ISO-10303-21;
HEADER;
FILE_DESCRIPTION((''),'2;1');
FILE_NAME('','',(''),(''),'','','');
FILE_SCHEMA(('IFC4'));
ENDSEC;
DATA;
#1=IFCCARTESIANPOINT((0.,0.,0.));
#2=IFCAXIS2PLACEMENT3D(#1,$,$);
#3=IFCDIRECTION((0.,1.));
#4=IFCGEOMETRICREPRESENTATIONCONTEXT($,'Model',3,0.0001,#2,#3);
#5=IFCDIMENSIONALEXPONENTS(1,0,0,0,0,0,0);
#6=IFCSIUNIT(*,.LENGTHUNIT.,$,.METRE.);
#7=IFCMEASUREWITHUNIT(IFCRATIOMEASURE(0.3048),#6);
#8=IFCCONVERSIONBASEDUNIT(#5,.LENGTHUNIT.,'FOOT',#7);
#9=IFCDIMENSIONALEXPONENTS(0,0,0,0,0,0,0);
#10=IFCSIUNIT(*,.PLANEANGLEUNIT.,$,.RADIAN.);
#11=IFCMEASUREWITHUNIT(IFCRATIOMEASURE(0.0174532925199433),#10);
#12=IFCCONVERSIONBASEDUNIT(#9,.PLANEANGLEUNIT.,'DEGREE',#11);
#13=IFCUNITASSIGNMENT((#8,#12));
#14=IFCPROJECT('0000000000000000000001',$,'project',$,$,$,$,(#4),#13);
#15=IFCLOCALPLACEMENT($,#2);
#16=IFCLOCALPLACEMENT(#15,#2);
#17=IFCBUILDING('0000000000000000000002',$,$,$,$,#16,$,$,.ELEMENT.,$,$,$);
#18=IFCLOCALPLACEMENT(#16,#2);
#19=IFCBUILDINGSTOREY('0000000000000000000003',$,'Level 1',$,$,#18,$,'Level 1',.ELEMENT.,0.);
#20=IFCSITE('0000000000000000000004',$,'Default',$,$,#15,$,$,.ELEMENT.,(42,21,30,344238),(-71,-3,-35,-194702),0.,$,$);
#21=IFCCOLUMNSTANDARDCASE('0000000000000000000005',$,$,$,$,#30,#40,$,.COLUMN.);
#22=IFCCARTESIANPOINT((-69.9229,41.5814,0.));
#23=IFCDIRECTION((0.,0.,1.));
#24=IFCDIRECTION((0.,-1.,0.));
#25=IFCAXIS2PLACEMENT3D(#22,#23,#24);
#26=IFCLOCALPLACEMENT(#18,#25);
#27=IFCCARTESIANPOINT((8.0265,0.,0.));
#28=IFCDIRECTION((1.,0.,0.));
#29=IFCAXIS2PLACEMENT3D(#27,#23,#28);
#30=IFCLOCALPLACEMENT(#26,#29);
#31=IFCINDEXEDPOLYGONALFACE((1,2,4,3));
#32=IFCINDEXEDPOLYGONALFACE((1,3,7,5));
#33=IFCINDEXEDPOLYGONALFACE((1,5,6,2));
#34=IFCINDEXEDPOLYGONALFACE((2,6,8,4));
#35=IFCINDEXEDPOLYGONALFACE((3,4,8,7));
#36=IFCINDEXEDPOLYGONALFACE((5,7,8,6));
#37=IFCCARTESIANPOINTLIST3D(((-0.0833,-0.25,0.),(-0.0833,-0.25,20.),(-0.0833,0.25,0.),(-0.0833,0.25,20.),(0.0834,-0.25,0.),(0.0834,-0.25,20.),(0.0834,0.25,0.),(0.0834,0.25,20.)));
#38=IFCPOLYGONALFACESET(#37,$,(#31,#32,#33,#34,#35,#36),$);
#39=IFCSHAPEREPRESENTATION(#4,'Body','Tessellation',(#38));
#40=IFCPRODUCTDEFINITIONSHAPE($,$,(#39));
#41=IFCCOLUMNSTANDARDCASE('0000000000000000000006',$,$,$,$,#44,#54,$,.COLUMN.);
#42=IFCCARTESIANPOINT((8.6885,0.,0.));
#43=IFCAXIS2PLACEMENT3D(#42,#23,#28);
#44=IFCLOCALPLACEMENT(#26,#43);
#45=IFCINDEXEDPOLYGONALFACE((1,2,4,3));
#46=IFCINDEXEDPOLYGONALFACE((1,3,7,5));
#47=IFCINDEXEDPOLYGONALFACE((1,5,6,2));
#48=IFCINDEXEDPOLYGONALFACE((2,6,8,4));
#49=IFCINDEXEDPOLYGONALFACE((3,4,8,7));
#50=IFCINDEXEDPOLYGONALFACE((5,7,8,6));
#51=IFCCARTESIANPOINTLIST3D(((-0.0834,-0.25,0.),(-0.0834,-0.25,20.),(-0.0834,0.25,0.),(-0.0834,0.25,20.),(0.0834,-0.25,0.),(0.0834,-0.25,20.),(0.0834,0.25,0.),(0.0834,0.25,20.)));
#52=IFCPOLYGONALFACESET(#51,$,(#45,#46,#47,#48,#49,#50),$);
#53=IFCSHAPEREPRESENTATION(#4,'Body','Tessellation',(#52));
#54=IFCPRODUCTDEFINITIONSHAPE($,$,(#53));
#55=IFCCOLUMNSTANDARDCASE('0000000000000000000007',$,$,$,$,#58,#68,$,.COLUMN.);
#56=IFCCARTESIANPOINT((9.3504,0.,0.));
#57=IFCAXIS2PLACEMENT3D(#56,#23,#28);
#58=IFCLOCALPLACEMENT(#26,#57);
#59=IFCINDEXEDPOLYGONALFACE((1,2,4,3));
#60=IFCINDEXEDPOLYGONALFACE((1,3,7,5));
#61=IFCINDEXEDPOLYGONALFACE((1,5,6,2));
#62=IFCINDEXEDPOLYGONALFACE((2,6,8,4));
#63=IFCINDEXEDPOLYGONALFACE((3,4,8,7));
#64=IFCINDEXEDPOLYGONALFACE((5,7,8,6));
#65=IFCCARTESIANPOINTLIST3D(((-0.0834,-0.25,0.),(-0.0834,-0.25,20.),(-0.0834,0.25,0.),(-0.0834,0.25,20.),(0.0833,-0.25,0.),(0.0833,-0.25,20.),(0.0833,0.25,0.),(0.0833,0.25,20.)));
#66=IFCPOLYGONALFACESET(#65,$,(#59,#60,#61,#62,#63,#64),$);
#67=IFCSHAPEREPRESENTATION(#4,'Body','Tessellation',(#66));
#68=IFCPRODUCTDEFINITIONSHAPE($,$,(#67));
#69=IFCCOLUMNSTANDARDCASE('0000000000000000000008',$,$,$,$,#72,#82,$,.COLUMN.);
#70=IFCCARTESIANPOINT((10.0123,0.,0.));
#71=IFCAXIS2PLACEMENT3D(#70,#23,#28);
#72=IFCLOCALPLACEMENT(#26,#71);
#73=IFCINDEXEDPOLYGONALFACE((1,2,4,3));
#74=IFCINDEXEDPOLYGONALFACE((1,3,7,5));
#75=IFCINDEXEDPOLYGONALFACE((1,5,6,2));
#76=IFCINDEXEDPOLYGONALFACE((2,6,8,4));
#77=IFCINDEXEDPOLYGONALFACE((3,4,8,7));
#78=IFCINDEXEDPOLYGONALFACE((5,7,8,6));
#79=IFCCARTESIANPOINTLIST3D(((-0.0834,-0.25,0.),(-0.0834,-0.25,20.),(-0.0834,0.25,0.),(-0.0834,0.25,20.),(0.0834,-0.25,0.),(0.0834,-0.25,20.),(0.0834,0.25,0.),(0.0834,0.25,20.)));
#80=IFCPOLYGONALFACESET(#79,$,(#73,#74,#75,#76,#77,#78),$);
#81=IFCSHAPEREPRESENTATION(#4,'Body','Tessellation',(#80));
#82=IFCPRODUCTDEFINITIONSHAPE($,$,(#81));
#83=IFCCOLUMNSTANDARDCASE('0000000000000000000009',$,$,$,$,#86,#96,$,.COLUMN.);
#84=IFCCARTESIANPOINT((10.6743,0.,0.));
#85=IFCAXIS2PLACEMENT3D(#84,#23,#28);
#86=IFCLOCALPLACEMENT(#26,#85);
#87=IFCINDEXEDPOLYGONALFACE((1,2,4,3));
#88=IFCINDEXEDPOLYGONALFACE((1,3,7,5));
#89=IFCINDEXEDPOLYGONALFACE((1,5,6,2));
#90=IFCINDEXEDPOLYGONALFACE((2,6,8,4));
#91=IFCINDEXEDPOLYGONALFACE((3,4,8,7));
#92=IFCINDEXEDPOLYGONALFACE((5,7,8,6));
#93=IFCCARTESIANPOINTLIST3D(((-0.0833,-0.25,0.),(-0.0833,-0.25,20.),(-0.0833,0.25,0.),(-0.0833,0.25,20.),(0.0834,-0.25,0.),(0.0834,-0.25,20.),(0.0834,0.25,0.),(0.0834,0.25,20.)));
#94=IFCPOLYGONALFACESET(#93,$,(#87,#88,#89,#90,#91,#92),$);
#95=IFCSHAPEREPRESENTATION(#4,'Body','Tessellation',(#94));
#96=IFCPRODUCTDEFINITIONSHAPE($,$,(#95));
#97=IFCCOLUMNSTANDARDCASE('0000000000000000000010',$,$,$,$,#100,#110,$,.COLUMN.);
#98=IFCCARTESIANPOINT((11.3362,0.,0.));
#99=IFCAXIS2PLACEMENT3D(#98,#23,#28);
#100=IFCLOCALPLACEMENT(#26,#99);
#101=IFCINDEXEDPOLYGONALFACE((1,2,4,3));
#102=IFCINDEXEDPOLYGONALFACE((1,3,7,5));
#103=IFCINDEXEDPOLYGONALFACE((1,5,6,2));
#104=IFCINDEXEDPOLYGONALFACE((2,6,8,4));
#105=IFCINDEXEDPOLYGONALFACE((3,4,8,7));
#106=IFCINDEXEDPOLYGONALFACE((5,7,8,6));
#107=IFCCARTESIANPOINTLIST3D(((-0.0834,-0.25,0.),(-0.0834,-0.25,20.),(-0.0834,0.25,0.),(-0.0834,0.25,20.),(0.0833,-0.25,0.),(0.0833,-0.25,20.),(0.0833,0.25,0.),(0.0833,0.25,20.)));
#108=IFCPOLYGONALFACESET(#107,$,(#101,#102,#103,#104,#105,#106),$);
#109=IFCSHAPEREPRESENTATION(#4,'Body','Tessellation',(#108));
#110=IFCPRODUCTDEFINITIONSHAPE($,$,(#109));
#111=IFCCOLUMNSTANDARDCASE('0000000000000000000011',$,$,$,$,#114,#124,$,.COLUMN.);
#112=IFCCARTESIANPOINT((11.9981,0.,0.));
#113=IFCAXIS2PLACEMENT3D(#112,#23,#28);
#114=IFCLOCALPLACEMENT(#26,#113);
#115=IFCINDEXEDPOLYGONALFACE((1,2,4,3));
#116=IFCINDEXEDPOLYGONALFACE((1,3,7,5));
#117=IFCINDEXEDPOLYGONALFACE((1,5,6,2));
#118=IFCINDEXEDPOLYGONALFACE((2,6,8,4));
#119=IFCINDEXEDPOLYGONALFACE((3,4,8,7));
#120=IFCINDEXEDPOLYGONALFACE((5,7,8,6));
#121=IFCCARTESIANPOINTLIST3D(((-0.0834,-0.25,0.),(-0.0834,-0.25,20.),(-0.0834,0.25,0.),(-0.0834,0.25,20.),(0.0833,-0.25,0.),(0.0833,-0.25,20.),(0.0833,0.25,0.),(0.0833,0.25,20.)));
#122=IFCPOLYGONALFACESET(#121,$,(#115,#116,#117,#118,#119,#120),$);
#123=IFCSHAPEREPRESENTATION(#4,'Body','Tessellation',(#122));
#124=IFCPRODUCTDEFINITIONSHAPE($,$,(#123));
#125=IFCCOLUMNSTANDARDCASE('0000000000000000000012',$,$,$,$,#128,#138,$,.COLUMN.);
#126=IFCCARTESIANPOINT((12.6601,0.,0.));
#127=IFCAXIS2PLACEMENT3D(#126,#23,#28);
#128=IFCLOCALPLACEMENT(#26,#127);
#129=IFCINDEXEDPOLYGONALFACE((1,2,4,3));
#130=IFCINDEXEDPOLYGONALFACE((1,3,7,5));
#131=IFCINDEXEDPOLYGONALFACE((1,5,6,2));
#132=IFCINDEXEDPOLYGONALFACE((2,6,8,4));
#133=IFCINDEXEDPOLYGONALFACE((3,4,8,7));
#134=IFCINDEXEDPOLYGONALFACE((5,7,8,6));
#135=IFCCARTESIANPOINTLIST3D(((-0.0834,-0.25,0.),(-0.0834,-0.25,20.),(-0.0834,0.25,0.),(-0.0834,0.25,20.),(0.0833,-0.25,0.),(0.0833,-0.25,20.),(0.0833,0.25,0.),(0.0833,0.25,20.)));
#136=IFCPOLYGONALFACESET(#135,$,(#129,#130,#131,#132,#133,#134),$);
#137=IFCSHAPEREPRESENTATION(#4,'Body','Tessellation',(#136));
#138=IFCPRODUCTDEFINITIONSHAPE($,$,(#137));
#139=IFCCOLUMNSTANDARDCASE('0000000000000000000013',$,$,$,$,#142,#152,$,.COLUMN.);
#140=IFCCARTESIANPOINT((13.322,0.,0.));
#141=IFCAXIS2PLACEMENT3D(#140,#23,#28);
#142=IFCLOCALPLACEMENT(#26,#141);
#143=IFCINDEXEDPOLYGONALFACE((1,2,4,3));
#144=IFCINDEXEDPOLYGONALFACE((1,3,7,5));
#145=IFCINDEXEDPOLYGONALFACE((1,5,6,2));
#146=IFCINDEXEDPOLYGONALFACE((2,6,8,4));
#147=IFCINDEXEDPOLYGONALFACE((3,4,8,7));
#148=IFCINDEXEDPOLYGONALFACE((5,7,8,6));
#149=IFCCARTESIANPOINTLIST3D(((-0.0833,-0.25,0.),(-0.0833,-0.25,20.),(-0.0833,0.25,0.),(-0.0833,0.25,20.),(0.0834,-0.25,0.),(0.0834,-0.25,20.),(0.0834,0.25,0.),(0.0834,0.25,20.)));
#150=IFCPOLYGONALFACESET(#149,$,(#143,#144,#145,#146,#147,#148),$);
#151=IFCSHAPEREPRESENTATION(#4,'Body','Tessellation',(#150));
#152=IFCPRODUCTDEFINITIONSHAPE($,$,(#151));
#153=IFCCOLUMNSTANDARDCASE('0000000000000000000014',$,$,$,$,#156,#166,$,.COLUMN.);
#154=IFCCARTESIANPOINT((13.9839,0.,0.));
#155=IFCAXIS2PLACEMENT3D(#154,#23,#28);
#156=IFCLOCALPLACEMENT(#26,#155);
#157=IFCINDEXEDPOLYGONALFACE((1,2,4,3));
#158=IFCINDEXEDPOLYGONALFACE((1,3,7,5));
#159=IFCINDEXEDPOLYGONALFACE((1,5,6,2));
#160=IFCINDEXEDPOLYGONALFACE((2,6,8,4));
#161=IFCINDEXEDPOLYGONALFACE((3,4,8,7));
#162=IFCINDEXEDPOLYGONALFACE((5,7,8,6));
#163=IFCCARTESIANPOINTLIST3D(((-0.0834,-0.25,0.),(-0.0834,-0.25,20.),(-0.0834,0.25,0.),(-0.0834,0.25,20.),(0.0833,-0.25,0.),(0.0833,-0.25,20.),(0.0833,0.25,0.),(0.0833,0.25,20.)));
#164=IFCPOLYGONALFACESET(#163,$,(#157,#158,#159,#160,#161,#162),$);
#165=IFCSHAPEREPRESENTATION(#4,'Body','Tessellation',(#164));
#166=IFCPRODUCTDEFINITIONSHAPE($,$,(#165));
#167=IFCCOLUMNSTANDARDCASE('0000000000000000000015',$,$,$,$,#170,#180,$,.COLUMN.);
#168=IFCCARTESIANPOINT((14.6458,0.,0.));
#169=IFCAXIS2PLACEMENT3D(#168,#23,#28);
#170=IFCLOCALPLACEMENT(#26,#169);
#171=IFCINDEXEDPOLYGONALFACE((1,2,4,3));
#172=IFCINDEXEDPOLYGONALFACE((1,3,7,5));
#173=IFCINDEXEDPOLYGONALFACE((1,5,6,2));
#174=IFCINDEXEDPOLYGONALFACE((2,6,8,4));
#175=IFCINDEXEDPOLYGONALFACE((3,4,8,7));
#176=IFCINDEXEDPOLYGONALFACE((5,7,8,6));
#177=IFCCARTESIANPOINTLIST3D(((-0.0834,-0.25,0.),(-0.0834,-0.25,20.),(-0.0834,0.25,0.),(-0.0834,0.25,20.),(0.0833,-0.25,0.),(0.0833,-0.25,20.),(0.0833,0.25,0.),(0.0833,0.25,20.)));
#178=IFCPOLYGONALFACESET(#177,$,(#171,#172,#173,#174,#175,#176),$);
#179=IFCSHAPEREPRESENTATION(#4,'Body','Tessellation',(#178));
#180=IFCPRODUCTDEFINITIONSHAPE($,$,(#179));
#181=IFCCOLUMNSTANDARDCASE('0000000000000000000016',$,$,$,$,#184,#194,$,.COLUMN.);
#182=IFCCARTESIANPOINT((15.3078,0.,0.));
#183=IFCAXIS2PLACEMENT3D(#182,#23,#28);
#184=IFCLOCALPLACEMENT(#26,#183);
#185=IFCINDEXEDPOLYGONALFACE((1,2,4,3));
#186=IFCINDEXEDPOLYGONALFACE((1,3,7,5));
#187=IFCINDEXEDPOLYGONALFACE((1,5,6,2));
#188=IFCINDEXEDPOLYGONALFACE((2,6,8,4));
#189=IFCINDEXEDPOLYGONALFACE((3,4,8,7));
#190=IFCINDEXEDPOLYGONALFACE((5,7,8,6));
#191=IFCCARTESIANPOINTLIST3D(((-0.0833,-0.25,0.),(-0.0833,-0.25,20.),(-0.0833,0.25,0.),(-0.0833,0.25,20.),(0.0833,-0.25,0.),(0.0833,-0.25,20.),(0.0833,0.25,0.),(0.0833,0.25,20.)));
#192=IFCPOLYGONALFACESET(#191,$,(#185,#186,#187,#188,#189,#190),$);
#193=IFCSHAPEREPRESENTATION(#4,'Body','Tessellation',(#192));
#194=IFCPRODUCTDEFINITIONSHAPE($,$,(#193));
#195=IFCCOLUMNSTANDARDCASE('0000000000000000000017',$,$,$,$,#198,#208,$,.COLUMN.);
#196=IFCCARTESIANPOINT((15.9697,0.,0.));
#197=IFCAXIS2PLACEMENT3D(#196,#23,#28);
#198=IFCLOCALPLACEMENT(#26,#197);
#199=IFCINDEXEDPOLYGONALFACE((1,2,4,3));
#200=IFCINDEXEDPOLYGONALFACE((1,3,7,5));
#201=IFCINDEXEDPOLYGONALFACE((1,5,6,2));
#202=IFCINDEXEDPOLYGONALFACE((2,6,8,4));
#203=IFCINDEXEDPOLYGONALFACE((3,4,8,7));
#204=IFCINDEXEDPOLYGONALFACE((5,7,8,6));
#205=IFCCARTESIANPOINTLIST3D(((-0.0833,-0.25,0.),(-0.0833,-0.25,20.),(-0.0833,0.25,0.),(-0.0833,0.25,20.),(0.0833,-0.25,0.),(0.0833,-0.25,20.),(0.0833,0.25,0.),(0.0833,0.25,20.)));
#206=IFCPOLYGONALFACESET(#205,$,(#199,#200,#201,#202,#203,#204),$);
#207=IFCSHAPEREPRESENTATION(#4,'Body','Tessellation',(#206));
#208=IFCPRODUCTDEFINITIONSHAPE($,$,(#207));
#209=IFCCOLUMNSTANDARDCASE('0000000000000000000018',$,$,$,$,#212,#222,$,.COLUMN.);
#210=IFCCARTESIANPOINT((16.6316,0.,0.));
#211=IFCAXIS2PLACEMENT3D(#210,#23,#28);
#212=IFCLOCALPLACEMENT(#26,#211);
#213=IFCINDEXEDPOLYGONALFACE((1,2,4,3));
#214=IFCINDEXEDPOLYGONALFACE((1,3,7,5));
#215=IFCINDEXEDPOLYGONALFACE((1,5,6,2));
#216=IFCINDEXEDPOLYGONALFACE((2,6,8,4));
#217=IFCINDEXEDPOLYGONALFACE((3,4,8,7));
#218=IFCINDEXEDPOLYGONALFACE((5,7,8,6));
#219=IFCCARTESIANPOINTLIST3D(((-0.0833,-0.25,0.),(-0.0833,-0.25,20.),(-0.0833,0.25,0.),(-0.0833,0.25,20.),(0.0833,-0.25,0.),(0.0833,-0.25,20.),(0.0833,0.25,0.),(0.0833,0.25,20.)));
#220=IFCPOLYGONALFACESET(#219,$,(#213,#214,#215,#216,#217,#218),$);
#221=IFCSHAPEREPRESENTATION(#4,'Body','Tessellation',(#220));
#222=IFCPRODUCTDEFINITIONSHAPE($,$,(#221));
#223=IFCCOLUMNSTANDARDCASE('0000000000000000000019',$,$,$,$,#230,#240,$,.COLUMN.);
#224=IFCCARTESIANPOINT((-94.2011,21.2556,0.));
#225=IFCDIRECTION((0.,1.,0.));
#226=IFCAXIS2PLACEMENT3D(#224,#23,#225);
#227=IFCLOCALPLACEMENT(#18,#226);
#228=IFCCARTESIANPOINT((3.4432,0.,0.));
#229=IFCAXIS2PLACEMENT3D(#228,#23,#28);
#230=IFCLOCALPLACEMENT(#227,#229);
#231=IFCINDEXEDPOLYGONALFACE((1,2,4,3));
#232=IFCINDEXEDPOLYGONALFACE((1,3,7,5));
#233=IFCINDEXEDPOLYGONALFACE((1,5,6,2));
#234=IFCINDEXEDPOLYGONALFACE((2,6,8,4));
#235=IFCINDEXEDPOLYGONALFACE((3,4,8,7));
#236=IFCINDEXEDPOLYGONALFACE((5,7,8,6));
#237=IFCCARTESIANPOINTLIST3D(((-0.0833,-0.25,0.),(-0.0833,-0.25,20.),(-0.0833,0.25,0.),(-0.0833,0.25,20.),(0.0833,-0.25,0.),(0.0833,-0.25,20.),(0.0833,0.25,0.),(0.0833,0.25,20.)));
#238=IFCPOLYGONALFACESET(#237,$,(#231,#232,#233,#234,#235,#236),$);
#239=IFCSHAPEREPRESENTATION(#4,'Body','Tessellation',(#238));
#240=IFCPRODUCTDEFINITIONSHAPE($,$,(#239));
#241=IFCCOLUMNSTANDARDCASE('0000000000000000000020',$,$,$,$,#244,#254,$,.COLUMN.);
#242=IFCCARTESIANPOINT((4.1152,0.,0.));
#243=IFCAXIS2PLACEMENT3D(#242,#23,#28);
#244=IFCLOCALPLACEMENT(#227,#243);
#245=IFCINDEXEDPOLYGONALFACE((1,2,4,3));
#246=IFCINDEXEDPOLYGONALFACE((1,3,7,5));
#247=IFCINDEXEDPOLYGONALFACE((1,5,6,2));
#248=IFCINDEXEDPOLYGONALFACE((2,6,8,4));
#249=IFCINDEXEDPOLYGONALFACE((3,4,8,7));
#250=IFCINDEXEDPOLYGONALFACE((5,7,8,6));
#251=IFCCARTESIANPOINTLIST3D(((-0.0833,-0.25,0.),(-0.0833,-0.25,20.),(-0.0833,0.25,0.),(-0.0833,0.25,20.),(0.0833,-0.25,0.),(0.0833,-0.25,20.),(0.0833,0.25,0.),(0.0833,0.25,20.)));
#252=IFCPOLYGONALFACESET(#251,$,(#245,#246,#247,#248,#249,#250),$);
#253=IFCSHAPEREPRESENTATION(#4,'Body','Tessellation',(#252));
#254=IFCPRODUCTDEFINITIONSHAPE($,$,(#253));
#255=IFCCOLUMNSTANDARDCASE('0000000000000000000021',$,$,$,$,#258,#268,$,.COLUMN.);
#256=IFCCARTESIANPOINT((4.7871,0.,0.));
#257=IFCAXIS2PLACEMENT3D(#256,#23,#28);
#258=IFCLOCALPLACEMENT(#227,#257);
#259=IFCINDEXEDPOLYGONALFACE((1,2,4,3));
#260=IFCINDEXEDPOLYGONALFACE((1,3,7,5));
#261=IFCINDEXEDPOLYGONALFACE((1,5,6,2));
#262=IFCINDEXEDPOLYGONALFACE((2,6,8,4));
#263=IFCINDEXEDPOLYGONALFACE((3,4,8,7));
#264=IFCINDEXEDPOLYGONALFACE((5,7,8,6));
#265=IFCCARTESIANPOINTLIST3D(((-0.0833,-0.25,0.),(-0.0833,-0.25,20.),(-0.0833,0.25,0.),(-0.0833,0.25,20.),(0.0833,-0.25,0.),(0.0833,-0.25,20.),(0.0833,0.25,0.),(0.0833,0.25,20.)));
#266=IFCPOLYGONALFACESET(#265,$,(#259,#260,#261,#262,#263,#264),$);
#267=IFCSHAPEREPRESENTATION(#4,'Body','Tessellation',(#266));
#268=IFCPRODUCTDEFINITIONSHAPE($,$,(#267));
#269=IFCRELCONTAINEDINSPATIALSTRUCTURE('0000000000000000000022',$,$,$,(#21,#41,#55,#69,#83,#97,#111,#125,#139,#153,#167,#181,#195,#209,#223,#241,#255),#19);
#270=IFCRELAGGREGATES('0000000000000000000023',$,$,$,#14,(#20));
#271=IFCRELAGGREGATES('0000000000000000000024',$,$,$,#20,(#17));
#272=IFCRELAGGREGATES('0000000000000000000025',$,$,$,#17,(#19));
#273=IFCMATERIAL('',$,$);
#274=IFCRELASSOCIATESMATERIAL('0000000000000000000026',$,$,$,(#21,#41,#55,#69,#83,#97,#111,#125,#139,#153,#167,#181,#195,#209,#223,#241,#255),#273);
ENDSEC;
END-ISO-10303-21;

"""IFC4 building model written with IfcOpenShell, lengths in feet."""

from ifc_helpers import new_model, entity, si_unit, converted_unit, direction, frame, origin, place, context, project, spatial, rectangle, extrude, material, element, save


model = new_model("IFC4")

# Units and contexts
model_context = context("Model", 3, precision=0.0001, world=origin(), true_north=direction((0.0, 1.0)))
ifc_project = project(units=[converted_unit("LENGTHUNIT", "FOOT", entity("IfcRatioMeasure", 0.3048), si_unit("LENGTHUNIT", "METRE"), dimensions=[1, 0, 0, 0, 0, 0, 0]), converted_unit("PLANEANGLEUNIT", "DEGREE", entity("IfcRatioMeasure", 0.0174532925199433), si_unit("PLANEANGLEUNIT", "RADIAN"), dimensions=[0, 0, 0, 0, 0, 0, 0])], contexts=[model_context])

# Site, building, storey
site_placement = place(None, origin())
site = spatial("IfcSite", under=ifc_project, at=site_placement, Name="Default", CompositionType="ELEMENT", RefLatitude=(42, 21, 30, 344238), RefLongitude=(-71, -3, -35, -194702), RefElevation=0.0)
building_placement = place(site_placement, origin())
building = spatial("IfcBuilding", under=site, at=building_placement, CompositionType="ELEMENT")
storey_placement = place(building_placement, origin())
storey = spatial("IfcBuildingStorey", under=building, at=storey_placement, Name="Level 1", LongName="Level 1", CompositionType="ELEMENT", Elevation=0.0)

# Columns
ifc_material_1 = material(Name="")
placement_1 = place(storey_placement, frame((-69.9229, 41.5814, 0.0), z_axis=(0.0, 0.0, 1.0), x_axis=(0.0, -1.0, 0.0)))
for number, where, z_axis, x_axis in (
    (1, (8.0265, 0.0, 0.0), (0.0, 0.0, 1.0), (1.0, 0.0, 0.0)),
    (2, (8.6885, 0.0, 0.0), (0.0, 0.0, 1.0), (1.0, 0.0, 0.0)),
    (3, (9.3504, 0.0, 0.0), (0.0, 0.0, 1.0), (1.0, 0.0, 0.0)),
    (4, (10.0123, 0.0, 0.0), (0.0, 0.0, 1.0), (1.0, 0.0, 0.0)),
    (5, (10.6743, 0.0, 0.0), (0.0, 0.0, 1.0), (1.0, 0.0, 0.0)),
    (6, (11.3362, 0.0, 0.0), (0.0, 0.0, 1.0), (1.0, 0.0, 0.0)),
    (7, (11.9981, 0.0, 0.0), (0.0, 0.0, 1.0), (1.0, 0.0, 0.0)),
    (8, (12.6601, 0.0, 0.0), (0.0, 0.0, 1.0), (1.0, 0.0, 0.0)),
    (9, (13.322, 0.0, 0.0), (0.0, 0.0, 1.0), (1.0, 0.0, 0.0)),
    (10, (13.9839, 0.0, 0.0), (0.0, 0.0, 1.0), (1.0, 0.0, 0.0)),
    (11, (14.6458, 0.0, 0.0), (0.0, 0.0, 1.0), (1.0, 0.0, 0.0)),
    (12, (15.3078, 0.0, 0.0), (0.0, 0.0, 1.0), (1.0, 0.0, 0.0)),
    (13, (15.9697, 0.0, 0.0), (0.0, 0.0, 1.0), (1.0, 0.0, 0.0)),
    (14, (16.6316, 0.0, 0.0), (0.0, 0.0, 1.0), (1.0, 0.0, 0.0)),
):
    element("IfcColumnStandardCase", number, at=place(placement_1, frame(where, z_axis=z_axis, x_axis=x_axis)), inside=storey, material=ifc_material_1, PredefinedType="COLUMN", context=model_context, shape_type="SweptSolid", body=[
        extrude(rectangle(XDim=0.1667, YDim=0.5), origin(), (0.0, 0.0, 1.0), 20.0),
    ])
placement_2 = place(storey_placement, frame((-94.2011, 21.2556, 0.0), z_axis=(0.0, 0.0, 1.0), x_axis=(0.0, 1.0, 0.0)))
for number, where, z_axis, x_axis in (
    (15, (3.4432, 0.0, 0.0), (0.0, 0.0, 1.0), (1.0, 0.0, 0.0)),
    (16, (4.1152, 0.0, 0.0), (0.0, 0.0, 1.0), (1.0, 0.0, 0.0)),
    (17, (4.7871, 0.0, 0.0), (0.0, 0.0, 1.0), (1.0, 0.0, 0.0)),
):
    element("IfcColumnStandardCase", number, at=place(placement_2, frame(where, z_axis=z_axis, x_axis=x_axis)), inside=storey, material=ifc_material_1, PredefinedType="COLUMN", context=model_context, shape_type="SweptSolid", body=[
        extrude(rectangle(XDim=0.1667, YDim=0.5), origin(), (0.0, 0.0, 1.0), 20.0),
    ])

save(model, "model.ifc")
